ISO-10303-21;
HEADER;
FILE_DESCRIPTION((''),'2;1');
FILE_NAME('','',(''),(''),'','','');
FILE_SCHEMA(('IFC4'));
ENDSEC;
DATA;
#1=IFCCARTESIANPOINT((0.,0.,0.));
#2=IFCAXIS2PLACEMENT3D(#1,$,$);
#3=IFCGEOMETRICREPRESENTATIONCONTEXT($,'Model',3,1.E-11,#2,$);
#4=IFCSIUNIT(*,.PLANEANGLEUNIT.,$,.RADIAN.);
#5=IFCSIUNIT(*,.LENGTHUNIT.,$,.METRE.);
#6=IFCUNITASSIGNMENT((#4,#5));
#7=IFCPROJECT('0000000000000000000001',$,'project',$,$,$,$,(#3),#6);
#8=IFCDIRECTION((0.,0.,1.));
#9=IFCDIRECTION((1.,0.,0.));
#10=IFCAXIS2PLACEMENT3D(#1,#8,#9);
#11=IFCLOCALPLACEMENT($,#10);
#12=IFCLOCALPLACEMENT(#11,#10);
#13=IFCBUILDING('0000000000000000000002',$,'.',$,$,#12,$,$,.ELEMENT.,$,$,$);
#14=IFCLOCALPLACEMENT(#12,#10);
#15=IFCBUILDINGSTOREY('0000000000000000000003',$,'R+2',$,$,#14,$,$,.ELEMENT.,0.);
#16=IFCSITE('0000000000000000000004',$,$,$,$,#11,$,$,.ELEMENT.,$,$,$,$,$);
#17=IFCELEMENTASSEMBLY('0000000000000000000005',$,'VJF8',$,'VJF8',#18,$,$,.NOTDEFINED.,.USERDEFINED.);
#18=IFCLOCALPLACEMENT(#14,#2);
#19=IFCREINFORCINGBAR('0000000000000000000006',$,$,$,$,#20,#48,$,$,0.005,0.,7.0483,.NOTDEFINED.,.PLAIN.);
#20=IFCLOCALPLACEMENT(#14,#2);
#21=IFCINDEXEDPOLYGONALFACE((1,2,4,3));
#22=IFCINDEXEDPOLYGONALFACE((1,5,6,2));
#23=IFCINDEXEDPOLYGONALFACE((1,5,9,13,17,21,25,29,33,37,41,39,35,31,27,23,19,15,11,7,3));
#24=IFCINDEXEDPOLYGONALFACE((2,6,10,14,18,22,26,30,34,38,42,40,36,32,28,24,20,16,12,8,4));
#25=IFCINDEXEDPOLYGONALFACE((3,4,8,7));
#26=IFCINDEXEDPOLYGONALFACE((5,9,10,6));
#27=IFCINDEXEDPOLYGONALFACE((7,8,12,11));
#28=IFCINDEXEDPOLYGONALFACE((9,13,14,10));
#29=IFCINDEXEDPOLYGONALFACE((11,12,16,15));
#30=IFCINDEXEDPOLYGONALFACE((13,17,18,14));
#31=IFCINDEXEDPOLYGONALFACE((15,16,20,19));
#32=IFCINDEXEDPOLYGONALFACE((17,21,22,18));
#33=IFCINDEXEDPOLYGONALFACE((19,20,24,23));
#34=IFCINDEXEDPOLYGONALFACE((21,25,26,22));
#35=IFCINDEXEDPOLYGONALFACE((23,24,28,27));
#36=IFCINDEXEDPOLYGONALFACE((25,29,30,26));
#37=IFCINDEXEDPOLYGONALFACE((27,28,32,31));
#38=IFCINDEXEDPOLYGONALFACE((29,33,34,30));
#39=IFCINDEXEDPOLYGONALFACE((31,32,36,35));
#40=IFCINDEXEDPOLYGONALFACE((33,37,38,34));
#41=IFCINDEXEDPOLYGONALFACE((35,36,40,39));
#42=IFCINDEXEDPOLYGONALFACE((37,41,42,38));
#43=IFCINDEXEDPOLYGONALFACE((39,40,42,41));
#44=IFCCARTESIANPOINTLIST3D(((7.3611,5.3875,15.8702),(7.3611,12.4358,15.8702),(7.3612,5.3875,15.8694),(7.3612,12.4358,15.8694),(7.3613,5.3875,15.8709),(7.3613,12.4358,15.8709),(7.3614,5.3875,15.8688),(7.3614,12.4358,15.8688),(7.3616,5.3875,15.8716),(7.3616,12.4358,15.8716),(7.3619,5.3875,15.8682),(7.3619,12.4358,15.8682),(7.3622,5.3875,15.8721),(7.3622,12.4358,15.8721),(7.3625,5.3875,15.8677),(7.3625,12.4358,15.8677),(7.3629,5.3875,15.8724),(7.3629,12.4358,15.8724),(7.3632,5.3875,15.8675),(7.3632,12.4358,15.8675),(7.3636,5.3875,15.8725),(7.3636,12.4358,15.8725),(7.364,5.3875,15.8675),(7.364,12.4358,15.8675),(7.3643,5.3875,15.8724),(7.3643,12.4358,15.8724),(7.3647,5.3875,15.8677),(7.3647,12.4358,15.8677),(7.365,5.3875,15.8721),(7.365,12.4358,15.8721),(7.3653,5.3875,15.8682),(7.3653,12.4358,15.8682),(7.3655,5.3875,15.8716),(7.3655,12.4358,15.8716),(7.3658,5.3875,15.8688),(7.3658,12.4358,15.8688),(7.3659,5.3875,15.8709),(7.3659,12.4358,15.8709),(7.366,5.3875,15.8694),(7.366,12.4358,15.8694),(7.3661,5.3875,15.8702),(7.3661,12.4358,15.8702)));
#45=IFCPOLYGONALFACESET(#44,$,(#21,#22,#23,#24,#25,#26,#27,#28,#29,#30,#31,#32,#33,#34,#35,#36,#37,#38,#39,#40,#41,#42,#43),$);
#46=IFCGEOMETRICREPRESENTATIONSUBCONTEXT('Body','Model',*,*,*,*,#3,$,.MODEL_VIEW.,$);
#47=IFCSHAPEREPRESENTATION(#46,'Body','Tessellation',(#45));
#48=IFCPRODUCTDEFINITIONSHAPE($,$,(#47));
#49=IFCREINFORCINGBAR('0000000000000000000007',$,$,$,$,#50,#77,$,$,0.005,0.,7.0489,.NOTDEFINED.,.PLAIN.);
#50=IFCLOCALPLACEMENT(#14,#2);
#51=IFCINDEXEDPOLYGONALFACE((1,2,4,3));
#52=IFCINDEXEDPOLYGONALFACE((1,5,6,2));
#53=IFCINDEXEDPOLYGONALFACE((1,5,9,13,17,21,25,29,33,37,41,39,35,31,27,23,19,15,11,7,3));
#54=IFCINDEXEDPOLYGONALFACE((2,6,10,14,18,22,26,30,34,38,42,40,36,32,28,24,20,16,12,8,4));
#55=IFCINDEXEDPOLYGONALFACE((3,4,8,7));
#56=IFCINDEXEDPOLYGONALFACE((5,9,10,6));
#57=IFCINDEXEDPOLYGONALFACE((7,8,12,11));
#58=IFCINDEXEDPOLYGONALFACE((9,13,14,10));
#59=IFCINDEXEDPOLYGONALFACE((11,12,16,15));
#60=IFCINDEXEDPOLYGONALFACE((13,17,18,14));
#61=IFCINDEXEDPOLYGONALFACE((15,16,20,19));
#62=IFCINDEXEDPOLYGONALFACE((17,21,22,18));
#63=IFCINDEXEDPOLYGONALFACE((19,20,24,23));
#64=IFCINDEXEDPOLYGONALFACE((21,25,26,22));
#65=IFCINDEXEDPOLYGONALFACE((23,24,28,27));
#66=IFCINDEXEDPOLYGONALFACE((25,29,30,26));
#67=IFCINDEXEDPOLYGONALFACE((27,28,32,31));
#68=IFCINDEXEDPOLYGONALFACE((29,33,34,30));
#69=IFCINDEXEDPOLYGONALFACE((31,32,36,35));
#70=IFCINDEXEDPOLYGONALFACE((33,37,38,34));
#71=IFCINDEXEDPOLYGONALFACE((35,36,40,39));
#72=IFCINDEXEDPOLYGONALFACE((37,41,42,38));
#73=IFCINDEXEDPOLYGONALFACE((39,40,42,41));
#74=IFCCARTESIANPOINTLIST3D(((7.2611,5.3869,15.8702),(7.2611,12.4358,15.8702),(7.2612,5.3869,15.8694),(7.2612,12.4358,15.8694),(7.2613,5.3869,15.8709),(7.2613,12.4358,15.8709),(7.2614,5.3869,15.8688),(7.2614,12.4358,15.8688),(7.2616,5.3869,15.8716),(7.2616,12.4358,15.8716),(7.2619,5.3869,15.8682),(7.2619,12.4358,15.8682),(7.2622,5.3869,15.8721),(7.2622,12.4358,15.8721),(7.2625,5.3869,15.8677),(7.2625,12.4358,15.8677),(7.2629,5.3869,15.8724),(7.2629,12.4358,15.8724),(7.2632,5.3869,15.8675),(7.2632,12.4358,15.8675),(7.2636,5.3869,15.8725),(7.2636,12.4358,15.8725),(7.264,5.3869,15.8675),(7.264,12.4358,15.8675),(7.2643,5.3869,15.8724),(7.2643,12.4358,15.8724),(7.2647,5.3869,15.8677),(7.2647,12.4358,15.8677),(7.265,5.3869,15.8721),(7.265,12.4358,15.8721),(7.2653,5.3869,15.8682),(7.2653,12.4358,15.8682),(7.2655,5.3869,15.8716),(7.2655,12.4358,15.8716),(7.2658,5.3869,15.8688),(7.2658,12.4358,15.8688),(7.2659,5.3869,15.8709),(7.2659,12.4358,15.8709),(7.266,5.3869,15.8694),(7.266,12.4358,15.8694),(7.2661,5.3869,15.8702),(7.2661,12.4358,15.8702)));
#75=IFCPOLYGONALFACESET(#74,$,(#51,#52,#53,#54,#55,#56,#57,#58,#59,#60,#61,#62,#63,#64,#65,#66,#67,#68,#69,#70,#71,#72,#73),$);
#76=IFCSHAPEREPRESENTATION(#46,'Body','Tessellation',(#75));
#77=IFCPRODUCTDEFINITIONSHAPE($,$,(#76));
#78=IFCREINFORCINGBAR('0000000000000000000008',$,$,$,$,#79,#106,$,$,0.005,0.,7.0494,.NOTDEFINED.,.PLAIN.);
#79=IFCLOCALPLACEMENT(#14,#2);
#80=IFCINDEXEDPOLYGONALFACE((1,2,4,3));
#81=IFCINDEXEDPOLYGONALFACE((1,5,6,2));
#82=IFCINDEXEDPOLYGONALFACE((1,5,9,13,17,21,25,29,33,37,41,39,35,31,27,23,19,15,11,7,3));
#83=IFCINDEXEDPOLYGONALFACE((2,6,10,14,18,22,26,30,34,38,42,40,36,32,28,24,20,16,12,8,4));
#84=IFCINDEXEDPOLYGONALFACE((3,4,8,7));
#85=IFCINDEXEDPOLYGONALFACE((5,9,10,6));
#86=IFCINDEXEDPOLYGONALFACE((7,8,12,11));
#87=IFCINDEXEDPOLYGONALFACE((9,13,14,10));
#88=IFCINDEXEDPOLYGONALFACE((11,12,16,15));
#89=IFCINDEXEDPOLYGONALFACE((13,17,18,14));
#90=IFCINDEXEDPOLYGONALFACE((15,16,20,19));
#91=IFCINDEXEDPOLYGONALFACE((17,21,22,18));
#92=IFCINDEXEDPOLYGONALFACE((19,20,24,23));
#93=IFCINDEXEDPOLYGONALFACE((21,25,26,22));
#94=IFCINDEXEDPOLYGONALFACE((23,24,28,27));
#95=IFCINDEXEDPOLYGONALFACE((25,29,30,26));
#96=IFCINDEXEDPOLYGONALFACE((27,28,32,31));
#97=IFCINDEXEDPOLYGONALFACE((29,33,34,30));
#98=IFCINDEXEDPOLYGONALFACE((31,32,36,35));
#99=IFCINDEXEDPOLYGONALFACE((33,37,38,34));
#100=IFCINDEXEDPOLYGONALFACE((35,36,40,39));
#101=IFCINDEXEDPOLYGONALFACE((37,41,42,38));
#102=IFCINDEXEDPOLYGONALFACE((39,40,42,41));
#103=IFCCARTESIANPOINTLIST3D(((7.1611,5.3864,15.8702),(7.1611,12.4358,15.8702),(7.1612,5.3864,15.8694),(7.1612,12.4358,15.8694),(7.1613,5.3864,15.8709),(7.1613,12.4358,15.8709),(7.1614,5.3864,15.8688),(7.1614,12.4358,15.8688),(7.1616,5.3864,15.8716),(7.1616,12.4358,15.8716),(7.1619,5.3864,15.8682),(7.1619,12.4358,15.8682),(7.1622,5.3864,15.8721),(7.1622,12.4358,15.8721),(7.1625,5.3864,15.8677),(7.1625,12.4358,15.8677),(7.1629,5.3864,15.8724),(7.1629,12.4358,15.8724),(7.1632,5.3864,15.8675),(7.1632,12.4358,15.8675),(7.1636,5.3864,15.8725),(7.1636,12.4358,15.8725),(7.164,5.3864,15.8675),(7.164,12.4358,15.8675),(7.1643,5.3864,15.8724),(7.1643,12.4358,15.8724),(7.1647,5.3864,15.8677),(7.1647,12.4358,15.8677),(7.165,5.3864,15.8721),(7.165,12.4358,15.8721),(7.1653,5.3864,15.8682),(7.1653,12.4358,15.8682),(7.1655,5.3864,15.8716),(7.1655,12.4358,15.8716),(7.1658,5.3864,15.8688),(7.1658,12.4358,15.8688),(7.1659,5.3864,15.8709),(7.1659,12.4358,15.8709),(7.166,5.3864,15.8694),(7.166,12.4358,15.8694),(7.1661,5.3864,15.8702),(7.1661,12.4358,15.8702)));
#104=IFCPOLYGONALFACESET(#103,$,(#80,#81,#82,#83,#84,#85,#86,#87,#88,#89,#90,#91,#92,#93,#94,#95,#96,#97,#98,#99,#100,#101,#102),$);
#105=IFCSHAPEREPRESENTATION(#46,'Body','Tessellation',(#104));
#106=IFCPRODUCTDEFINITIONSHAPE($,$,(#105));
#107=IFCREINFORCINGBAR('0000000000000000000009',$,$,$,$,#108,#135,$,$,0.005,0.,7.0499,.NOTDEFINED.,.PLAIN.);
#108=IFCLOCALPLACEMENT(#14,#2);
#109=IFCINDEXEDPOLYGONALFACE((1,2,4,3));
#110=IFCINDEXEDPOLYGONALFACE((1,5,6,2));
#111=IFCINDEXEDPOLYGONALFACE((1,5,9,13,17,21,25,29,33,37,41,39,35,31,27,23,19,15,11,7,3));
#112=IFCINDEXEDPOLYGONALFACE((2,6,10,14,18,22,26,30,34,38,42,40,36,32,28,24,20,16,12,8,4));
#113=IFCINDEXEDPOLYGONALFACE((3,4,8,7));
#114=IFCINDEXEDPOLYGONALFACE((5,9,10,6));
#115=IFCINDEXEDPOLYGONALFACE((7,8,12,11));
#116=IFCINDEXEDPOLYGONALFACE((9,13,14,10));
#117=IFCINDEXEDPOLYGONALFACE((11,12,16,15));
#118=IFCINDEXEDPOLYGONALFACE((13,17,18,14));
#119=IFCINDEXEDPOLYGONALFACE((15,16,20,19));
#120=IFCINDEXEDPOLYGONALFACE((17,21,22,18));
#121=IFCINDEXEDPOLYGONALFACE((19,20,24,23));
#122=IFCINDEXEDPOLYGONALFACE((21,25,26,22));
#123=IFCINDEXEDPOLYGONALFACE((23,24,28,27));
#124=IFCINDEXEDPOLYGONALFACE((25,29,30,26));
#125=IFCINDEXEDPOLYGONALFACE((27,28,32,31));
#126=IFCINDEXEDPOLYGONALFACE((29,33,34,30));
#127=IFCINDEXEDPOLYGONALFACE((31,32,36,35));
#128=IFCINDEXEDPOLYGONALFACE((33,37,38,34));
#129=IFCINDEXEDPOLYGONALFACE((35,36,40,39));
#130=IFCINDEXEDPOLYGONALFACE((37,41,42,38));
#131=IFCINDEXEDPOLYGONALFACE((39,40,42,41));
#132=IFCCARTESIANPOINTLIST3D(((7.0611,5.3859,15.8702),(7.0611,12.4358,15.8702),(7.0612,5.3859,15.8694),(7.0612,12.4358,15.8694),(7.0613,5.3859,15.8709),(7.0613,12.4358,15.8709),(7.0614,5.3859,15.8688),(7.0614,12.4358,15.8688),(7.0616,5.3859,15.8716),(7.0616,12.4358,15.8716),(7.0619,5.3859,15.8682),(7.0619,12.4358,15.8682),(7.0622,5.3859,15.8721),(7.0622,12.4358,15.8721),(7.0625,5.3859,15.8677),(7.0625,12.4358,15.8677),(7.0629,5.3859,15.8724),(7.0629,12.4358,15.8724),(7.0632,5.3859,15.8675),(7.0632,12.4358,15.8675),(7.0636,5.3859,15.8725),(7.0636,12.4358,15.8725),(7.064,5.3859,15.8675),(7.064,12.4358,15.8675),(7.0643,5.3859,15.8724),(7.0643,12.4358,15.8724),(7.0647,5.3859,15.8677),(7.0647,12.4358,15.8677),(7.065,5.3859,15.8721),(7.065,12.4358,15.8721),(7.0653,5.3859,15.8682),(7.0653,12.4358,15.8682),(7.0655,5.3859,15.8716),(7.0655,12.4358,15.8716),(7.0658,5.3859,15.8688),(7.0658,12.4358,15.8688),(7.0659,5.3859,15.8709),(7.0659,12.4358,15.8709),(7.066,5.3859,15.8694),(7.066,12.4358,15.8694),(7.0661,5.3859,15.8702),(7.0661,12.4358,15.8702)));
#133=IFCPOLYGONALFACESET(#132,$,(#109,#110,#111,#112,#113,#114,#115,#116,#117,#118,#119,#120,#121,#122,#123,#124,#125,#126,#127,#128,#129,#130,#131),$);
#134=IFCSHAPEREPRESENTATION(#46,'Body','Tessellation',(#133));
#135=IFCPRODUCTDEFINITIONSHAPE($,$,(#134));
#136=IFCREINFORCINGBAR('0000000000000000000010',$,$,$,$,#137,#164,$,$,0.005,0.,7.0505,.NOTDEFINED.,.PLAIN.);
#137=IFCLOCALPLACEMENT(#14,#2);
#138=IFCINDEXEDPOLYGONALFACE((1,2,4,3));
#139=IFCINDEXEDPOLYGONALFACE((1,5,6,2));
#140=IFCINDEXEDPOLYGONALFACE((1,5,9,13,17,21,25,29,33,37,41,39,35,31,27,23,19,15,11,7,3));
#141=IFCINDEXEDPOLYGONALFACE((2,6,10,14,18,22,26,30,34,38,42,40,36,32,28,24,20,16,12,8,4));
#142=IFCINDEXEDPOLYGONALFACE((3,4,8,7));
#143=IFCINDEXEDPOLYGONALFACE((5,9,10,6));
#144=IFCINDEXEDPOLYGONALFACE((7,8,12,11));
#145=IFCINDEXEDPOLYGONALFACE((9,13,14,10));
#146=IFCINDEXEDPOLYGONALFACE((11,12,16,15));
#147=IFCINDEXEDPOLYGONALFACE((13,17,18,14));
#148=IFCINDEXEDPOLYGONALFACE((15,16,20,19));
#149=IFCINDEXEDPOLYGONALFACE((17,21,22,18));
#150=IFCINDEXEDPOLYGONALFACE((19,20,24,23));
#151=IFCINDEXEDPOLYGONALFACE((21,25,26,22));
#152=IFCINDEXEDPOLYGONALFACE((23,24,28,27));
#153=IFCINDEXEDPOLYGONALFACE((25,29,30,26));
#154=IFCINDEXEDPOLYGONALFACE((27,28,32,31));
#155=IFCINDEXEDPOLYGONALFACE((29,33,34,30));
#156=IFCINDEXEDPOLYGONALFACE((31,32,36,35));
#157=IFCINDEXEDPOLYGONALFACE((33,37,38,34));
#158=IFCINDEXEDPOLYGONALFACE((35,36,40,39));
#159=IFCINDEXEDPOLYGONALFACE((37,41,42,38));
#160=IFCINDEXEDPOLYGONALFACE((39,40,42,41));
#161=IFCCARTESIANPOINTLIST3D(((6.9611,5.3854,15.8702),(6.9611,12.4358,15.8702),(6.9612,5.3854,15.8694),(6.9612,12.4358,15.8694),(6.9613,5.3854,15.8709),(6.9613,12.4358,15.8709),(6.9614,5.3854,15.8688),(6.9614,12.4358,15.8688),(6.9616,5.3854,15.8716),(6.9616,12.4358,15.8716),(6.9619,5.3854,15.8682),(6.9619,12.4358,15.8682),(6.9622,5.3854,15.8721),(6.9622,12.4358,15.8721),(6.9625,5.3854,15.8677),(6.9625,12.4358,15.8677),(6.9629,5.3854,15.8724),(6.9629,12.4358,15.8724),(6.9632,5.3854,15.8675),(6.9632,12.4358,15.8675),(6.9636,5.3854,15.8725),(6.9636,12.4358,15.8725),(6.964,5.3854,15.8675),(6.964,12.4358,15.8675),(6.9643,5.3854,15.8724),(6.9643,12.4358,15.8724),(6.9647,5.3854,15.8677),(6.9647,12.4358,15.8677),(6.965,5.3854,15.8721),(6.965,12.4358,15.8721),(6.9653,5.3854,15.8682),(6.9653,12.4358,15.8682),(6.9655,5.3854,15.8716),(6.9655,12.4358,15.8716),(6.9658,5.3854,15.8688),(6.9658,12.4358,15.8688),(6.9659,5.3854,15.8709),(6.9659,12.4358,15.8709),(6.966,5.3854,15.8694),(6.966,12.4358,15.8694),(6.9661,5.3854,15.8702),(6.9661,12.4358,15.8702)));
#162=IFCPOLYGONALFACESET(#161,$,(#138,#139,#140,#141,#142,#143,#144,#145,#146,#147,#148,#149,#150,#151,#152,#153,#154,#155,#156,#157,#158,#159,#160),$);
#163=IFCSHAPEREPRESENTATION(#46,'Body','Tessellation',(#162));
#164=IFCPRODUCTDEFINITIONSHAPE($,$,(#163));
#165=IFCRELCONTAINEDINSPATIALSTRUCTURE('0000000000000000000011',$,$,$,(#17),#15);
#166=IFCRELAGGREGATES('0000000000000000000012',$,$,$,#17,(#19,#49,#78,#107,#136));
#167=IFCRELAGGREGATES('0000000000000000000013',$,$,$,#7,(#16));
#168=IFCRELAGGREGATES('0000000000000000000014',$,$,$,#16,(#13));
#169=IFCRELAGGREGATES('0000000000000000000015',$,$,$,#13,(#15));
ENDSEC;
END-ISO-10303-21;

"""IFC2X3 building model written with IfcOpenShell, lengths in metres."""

from ifc_helpers import new_model, entity, si_unit, origin, origin_with_axes, place, context, subcontext, project, spatial, shape, element, aggregate, save


model = new_model("IFC2X3")

# Units and contexts
model_context = context("Model", 3, precision=1e-11, world=origin())
body_context = subcontext(model_context, "Body", "Model", "MODEL_VIEW")
ifc_project = project(units=[si_unit("PLANEANGLEUNIT", "RADIAN"), si_unit("LENGTHUNIT", "METRE")], contexts=[model_context])

# Site, building, storey
site_placement = place(None, origin_with_axes())
site = spatial("IfcSite", under=ifc_project, at=site_placement, CompositionType="ELEMENT")
building_placement = place(site_placement, origin_with_axes())
building = spatial("IfcBuilding", under=site, at=building_placement, Name=".", CompositionType="ELEMENT")
storey_placement = place(building_placement, origin_with_axes())
storey = spatial("IfcBuildingStorey", under=building, at=storey_placement, Name="R+2", CompositionType="ELEMENT", Elevation=0.0)

# Element assembly, reinforcing bars
assembly_1_placement = place(storey_placement, origin_with_axes())
assembly_1 = element("IfcElementAssembly", 1, at=assembly_1_placement, inside=storey, Name="VJF8", ObjectType="VJF8", AssemblyPlace="NOTDEFINED", PredefinedType="USERDEFINED")
reinforcing_bar_1_placement = place(assembly_1_placement, origin_with_axes())
reinforcing_bar_1 = element("IfcReinforcingBar", 2, at=reinforcing_bar_1_placement, BarLength=7.0483, BarRole="NOTDEFINED", BarSurface="PLAIN", CrossSectionArea=0.0, NominalDiameter=0.005, shapes=[
    shape(body_context, "Body", "AdvancedSweptSolid", [entity("IfcSweptDiskSolid", entity("IfcPolyline", [entity("IfcCartesianPoint", [7.3636, 5.3875, 15.87]), entity("IfcCartesianPoint", [7.3636, 12.4358, 15.87])]), 0.0025, None, 0.0, 7.0483)]),
    shape(body_context, "Body", "AdvancedSweptSolid", [entity("IfcSweptDiskSolid", entity("IfcPolyline", [entity("IfcCartesianPoint", [7.3636, 5.3875, 15.87]), entity("IfcCartesianPoint", [7.3636, 12.4358, 15.87])]), 0.0025, None, 0.0, 7.0483)]),
])
reinforcing_bar_2_placement = place(assembly_1_placement, origin_with_axes())
reinforcing_bar_2 = element("IfcReinforcingBar", 3, at=reinforcing_bar_2_placement, BarLength=7.0489, BarRole="NOTDEFINED", BarSurface="PLAIN", CrossSectionArea=0.0, NominalDiameter=0.005, shapes=[
    shape(body_context, "Body", "AdvancedSweptSolid", [entity("IfcSweptDiskSolid", entity("IfcPolyline", [entity("IfcCartesianPoint", [7.2636, 5.3869, 15.87]), entity("IfcCartesianPoint", [7.2636, 12.4358, 15.87])]), 0.0025, None, 0.0, 7.0489)]),
    shape(body_context, "Body", "AdvancedSweptSolid", [entity("IfcSweptDiskSolid", entity("IfcPolyline", [entity("IfcCartesianPoint", [7.2636, 5.3869, 15.87]), entity("IfcCartesianPoint", [7.2636, 12.4358, 15.87])]), 0.0025, None, 0.0, 7.0489)]),
])
reinforcing_bar_3_placement = place(assembly_1_placement, origin_with_axes())
reinforcing_bar_3 = element("IfcReinforcingBar", 4, at=reinforcing_bar_3_placement, BarLength=7.0494, BarRole="NOTDEFINED", BarSurface="PLAIN", CrossSectionArea=0.0, NominalDiameter=0.005, shapes=[
    shape(body_context, "Body", "AdvancedSweptSolid", [entity("IfcSweptDiskSolid", entity("IfcPolyline", [entity("IfcCartesianPoint", [7.1636, 5.3864, 15.87]), entity("IfcCartesianPoint", [7.1636, 12.4358, 15.87])]), 0.0025, None, 0.0, 7.0494)]),
    shape(body_context, "Body", "AdvancedSweptSolid", [entity("IfcSweptDiskSolid", entity("IfcPolyline", [entity("IfcCartesianPoint", [7.1636, 5.3864, 15.87]), entity("IfcCartesianPoint", [7.1636, 12.4358, 15.87])]), 0.0025, None, 0.0, 7.0494)]),
])
reinforcing_bar_4_placement = place(assembly_1_placement, origin_with_axes())
reinforcing_bar_4 = element("IfcReinforcingBar", 5, at=reinforcing_bar_4_placement, BarLength=7.0499, BarRole="NOTDEFINED", BarSurface="PLAIN", CrossSectionArea=0.0, NominalDiameter=0.005, shapes=[
    shape(body_context, "Body", "AdvancedSweptSolid", [entity("IfcSweptDiskSolid", entity("IfcPolyline", [entity("IfcCartesianPoint", [7.0636, 5.3859, 15.87]), entity("IfcCartesianPoint", [7.0636, 12.4358, 15.87])]), 0.0025, None, 0.0, 7.0499)]),
    shape(body_context, "Body", "AdvancedSweptSolid", [entity("IfcSweptDiskSolid", entity("IfcPolyline", [entity("IfcCartesianPoint", [7.0636, 5.3859, 15.87]), entity("IfcCartesianPoint", [7.0636, 12.4358, 15.87])]), 0.0025, None, 0.0, 7.0499)]),
])
reinforcing_bar_5_placement = place(assembly_1_placement, origin_with_axes())
reinforcing_bar_5 = element("IfcReinforcingBar", 6, at=reinforcing_bar_5_placement, BarLength=7.0505, BarRole="NOTDEFINED", BarSurface="PLAIN", CrossSectionArea=0.0, NominalDiameter=0.005, shapes=[
    shape(body_context, "Body", "AdvancedSweptSolid", [entity("IfcSweptDiskSolid", entity("IfcPolyline", [entity("IfcCartesianPoint", [6.9636, 5.3854, 15.87]), entity("IfcCartesianPoint", [6.9636, 12.4358, 15.87])]), 0.0025, None, 0.0, 7.0505)]),
    shape(body_context, "Body", "AdvancedSweptSolid", [entity("IfcSweptDiskSolid", entity("IfcPolyline", [entity("IfcCartesianPoint", [6.9636, 5.3854, 15.87]), entity("IfcCartesianPoint", [6.9636, 12.4358, 15.87])]), 0.0025, None, 0.0, 7.0505)]),
])
aggregate(assembly_1, [reinforcing_bar_1, reinforcing_bar_2, reinforcing_bar_3, reinforcing_bar_4, reinforcing_bar_5])

save(model, "model.ifc")
